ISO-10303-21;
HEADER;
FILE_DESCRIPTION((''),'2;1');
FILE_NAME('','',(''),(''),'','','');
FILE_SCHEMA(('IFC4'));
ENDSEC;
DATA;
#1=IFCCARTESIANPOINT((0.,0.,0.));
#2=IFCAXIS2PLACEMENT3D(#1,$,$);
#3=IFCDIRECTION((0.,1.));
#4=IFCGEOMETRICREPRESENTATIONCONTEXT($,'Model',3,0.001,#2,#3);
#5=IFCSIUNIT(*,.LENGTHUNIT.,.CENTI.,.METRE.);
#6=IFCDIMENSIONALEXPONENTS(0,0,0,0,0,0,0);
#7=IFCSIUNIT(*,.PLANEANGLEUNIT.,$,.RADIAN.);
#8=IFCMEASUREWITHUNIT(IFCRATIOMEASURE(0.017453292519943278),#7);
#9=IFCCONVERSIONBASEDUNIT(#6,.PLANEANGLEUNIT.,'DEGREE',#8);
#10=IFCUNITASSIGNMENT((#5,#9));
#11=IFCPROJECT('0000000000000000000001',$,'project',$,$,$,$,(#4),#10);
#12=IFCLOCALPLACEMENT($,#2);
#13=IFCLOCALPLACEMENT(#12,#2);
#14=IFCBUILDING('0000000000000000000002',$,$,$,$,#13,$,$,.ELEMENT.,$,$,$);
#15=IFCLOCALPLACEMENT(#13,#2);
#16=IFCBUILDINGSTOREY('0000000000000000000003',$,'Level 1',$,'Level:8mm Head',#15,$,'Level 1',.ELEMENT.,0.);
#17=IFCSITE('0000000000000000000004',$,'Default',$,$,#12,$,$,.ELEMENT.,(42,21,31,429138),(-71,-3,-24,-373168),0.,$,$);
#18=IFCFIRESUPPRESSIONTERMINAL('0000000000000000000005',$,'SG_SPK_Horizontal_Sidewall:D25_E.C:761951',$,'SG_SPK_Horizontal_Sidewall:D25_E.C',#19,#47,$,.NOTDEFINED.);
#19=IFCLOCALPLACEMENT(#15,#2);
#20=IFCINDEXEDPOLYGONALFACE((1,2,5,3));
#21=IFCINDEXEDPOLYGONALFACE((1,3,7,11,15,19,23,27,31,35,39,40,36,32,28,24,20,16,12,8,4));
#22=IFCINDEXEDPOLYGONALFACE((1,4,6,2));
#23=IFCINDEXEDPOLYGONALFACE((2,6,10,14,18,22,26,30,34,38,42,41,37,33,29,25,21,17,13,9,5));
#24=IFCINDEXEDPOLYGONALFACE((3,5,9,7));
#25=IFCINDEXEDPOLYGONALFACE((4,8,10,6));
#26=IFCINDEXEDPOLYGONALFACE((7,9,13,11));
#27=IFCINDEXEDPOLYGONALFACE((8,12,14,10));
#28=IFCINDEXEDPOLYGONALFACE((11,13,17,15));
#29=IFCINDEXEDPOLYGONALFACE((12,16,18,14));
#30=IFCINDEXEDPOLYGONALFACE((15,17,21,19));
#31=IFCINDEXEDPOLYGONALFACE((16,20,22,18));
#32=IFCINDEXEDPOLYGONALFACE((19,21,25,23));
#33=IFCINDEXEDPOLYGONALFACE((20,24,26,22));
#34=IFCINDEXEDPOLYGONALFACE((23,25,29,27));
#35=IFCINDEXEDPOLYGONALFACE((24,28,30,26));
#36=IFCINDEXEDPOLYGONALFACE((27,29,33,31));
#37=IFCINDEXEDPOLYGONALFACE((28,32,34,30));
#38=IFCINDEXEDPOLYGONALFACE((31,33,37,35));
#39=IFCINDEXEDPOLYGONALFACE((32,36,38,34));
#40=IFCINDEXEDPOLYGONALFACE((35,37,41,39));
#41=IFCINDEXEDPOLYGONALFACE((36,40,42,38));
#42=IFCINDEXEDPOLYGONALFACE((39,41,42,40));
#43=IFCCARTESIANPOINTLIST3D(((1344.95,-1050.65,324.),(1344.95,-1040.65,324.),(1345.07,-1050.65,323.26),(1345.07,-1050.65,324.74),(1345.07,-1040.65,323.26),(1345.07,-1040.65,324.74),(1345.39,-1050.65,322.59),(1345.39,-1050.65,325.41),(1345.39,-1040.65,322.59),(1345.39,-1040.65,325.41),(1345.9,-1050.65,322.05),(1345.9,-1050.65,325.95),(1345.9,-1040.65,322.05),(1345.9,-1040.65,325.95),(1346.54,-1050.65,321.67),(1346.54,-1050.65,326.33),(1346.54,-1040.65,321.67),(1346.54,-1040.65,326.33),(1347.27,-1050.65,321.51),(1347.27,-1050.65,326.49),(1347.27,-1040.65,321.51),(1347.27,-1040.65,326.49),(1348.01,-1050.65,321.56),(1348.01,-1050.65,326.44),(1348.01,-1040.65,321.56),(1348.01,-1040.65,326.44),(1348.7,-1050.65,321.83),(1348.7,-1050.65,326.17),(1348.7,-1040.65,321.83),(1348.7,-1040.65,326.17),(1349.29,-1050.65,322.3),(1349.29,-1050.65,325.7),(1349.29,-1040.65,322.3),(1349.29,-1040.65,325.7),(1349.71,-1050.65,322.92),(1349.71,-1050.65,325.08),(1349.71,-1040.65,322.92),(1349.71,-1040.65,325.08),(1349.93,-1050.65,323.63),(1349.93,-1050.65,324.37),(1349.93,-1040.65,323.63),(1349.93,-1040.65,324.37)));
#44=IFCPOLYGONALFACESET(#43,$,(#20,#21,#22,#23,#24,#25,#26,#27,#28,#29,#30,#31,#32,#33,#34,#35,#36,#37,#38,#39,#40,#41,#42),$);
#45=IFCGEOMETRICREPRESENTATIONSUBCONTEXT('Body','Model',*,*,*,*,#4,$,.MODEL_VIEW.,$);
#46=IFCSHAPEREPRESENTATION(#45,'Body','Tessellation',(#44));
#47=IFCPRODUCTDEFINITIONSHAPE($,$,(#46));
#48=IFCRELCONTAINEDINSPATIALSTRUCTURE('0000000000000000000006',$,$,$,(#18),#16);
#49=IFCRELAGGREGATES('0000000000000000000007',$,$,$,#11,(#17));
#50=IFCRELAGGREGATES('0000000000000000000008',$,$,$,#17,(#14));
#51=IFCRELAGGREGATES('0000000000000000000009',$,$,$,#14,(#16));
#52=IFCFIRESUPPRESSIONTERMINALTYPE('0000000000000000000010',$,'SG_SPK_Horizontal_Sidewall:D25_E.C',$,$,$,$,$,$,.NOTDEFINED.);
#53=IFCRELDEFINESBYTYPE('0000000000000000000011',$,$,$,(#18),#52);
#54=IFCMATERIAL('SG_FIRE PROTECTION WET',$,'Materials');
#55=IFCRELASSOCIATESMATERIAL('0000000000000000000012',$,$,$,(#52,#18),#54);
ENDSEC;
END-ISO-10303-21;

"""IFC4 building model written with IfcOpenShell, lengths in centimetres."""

from ifc_helpers import new_model, entity, si_unit, converted_unit, direction, frame, frame_2d, origin, place, context, subcontext, project, spatial, circle, extrude, source, transform, mapped, material, type_object, type_shapes, element, save


model = new_model("IFC4")

# Units and contexts
model_context = context("Model", 3, precision=0.001, world=origin(), true_north=direction((0.0, 1.0)))
body_context = subcontext(model_context, "Body", "Model", "MODEL_VIEW")
ifc_project = project(units=[si_unit("LENGTHUNIT", "METRE", prefix="CENTI"), converted_unit("PLANEANGLEUNIT", "DEGREE", entity("IfcRatioMeasure", 0.017453292519943278), si_unit("PLANEANGLEUNIT", "RADIAN"), dimensions=[0, 0, 0, 0, 0, 0, 0])], contexts=[model_context])

# Site, building, storey
site_placement = place(None, origin())
site = spatial("IfcSite", under=ifc_project, at=site_placement, Name="Default", CompositionType="ELEMENT", RefLatitude=(42, 21, 31, 429138), RefLongitude=(-71, -3, -24, -373168), RefElevation=0.0)
building_placement = place(site_placement, origin())
building = spatial("IfcBuilding", under=site, at=building_placement, CompositionType="ELEMENT")
storey_placement = place(building_placement, origin())
storey = spatial("IfcBuildingStorey", under=building, at=storey_placement, Name="Level 1", ObjectType="Level:8mm Head", LongName="Level 1", CompositionType="ELEMENT", Elevation=0.0)

# Fire suppression terminal
ifc_material_1 = material(Name="SG_FIRE PROTECTION WET", Category="Materials")
fire_suppression_terminal_type = type_object("IfcFireSuppressionTerminalType", Name="SG_SPK_Horizontal_Sidewall:D25_E.C", PredefinedType="NOTDEFINED", material=ifc_material_1)
shared_shape_1 = source(origin(), body_context, "Body", "SweptSolid", [
    extrude(circle(Radius=2.5, at=frame_2d((0.0, 0.0), x_axis=(1.0, 0.0))), frame((0.0, 0.0, 0.0), z_axis=(1.0, 0.0, 0.0), x_axis=(0.0, 1.0, 0.0)), (0.0, 0.0, 1.0), 10.0),
])
type_shapes(fire_suppression_terminal_type, [shared_shape_1])
fire_suppression_terminal_placement = place(storey_placement, frame((1347.45, -1050.65, 324.0), z_axis=(0.0, 0.0, 1.0), x_axis=(0.0, 1.0, 0.0)))
element("IfcFireSuppressionTerminal", 1, at=fire_suppression_terminal_placement, inside=storey, type_object=fire_suppression_terminal_type, material=ifc_material_1, Name="SG_SPK_Horizontal_Sidewall:D25_E.C:761951", ObjectType="SG_SPK_Horizontal_Sidewall:D25_E.C", PredefinedType="NOTDEFINED", context=body_context, shape_type="MappedRepresentation", body=[
    mapped(shared_shape_1, transform((0.0, 0.0, 0.0), scale=1.0)),
])

save(model, "model.ifc")
